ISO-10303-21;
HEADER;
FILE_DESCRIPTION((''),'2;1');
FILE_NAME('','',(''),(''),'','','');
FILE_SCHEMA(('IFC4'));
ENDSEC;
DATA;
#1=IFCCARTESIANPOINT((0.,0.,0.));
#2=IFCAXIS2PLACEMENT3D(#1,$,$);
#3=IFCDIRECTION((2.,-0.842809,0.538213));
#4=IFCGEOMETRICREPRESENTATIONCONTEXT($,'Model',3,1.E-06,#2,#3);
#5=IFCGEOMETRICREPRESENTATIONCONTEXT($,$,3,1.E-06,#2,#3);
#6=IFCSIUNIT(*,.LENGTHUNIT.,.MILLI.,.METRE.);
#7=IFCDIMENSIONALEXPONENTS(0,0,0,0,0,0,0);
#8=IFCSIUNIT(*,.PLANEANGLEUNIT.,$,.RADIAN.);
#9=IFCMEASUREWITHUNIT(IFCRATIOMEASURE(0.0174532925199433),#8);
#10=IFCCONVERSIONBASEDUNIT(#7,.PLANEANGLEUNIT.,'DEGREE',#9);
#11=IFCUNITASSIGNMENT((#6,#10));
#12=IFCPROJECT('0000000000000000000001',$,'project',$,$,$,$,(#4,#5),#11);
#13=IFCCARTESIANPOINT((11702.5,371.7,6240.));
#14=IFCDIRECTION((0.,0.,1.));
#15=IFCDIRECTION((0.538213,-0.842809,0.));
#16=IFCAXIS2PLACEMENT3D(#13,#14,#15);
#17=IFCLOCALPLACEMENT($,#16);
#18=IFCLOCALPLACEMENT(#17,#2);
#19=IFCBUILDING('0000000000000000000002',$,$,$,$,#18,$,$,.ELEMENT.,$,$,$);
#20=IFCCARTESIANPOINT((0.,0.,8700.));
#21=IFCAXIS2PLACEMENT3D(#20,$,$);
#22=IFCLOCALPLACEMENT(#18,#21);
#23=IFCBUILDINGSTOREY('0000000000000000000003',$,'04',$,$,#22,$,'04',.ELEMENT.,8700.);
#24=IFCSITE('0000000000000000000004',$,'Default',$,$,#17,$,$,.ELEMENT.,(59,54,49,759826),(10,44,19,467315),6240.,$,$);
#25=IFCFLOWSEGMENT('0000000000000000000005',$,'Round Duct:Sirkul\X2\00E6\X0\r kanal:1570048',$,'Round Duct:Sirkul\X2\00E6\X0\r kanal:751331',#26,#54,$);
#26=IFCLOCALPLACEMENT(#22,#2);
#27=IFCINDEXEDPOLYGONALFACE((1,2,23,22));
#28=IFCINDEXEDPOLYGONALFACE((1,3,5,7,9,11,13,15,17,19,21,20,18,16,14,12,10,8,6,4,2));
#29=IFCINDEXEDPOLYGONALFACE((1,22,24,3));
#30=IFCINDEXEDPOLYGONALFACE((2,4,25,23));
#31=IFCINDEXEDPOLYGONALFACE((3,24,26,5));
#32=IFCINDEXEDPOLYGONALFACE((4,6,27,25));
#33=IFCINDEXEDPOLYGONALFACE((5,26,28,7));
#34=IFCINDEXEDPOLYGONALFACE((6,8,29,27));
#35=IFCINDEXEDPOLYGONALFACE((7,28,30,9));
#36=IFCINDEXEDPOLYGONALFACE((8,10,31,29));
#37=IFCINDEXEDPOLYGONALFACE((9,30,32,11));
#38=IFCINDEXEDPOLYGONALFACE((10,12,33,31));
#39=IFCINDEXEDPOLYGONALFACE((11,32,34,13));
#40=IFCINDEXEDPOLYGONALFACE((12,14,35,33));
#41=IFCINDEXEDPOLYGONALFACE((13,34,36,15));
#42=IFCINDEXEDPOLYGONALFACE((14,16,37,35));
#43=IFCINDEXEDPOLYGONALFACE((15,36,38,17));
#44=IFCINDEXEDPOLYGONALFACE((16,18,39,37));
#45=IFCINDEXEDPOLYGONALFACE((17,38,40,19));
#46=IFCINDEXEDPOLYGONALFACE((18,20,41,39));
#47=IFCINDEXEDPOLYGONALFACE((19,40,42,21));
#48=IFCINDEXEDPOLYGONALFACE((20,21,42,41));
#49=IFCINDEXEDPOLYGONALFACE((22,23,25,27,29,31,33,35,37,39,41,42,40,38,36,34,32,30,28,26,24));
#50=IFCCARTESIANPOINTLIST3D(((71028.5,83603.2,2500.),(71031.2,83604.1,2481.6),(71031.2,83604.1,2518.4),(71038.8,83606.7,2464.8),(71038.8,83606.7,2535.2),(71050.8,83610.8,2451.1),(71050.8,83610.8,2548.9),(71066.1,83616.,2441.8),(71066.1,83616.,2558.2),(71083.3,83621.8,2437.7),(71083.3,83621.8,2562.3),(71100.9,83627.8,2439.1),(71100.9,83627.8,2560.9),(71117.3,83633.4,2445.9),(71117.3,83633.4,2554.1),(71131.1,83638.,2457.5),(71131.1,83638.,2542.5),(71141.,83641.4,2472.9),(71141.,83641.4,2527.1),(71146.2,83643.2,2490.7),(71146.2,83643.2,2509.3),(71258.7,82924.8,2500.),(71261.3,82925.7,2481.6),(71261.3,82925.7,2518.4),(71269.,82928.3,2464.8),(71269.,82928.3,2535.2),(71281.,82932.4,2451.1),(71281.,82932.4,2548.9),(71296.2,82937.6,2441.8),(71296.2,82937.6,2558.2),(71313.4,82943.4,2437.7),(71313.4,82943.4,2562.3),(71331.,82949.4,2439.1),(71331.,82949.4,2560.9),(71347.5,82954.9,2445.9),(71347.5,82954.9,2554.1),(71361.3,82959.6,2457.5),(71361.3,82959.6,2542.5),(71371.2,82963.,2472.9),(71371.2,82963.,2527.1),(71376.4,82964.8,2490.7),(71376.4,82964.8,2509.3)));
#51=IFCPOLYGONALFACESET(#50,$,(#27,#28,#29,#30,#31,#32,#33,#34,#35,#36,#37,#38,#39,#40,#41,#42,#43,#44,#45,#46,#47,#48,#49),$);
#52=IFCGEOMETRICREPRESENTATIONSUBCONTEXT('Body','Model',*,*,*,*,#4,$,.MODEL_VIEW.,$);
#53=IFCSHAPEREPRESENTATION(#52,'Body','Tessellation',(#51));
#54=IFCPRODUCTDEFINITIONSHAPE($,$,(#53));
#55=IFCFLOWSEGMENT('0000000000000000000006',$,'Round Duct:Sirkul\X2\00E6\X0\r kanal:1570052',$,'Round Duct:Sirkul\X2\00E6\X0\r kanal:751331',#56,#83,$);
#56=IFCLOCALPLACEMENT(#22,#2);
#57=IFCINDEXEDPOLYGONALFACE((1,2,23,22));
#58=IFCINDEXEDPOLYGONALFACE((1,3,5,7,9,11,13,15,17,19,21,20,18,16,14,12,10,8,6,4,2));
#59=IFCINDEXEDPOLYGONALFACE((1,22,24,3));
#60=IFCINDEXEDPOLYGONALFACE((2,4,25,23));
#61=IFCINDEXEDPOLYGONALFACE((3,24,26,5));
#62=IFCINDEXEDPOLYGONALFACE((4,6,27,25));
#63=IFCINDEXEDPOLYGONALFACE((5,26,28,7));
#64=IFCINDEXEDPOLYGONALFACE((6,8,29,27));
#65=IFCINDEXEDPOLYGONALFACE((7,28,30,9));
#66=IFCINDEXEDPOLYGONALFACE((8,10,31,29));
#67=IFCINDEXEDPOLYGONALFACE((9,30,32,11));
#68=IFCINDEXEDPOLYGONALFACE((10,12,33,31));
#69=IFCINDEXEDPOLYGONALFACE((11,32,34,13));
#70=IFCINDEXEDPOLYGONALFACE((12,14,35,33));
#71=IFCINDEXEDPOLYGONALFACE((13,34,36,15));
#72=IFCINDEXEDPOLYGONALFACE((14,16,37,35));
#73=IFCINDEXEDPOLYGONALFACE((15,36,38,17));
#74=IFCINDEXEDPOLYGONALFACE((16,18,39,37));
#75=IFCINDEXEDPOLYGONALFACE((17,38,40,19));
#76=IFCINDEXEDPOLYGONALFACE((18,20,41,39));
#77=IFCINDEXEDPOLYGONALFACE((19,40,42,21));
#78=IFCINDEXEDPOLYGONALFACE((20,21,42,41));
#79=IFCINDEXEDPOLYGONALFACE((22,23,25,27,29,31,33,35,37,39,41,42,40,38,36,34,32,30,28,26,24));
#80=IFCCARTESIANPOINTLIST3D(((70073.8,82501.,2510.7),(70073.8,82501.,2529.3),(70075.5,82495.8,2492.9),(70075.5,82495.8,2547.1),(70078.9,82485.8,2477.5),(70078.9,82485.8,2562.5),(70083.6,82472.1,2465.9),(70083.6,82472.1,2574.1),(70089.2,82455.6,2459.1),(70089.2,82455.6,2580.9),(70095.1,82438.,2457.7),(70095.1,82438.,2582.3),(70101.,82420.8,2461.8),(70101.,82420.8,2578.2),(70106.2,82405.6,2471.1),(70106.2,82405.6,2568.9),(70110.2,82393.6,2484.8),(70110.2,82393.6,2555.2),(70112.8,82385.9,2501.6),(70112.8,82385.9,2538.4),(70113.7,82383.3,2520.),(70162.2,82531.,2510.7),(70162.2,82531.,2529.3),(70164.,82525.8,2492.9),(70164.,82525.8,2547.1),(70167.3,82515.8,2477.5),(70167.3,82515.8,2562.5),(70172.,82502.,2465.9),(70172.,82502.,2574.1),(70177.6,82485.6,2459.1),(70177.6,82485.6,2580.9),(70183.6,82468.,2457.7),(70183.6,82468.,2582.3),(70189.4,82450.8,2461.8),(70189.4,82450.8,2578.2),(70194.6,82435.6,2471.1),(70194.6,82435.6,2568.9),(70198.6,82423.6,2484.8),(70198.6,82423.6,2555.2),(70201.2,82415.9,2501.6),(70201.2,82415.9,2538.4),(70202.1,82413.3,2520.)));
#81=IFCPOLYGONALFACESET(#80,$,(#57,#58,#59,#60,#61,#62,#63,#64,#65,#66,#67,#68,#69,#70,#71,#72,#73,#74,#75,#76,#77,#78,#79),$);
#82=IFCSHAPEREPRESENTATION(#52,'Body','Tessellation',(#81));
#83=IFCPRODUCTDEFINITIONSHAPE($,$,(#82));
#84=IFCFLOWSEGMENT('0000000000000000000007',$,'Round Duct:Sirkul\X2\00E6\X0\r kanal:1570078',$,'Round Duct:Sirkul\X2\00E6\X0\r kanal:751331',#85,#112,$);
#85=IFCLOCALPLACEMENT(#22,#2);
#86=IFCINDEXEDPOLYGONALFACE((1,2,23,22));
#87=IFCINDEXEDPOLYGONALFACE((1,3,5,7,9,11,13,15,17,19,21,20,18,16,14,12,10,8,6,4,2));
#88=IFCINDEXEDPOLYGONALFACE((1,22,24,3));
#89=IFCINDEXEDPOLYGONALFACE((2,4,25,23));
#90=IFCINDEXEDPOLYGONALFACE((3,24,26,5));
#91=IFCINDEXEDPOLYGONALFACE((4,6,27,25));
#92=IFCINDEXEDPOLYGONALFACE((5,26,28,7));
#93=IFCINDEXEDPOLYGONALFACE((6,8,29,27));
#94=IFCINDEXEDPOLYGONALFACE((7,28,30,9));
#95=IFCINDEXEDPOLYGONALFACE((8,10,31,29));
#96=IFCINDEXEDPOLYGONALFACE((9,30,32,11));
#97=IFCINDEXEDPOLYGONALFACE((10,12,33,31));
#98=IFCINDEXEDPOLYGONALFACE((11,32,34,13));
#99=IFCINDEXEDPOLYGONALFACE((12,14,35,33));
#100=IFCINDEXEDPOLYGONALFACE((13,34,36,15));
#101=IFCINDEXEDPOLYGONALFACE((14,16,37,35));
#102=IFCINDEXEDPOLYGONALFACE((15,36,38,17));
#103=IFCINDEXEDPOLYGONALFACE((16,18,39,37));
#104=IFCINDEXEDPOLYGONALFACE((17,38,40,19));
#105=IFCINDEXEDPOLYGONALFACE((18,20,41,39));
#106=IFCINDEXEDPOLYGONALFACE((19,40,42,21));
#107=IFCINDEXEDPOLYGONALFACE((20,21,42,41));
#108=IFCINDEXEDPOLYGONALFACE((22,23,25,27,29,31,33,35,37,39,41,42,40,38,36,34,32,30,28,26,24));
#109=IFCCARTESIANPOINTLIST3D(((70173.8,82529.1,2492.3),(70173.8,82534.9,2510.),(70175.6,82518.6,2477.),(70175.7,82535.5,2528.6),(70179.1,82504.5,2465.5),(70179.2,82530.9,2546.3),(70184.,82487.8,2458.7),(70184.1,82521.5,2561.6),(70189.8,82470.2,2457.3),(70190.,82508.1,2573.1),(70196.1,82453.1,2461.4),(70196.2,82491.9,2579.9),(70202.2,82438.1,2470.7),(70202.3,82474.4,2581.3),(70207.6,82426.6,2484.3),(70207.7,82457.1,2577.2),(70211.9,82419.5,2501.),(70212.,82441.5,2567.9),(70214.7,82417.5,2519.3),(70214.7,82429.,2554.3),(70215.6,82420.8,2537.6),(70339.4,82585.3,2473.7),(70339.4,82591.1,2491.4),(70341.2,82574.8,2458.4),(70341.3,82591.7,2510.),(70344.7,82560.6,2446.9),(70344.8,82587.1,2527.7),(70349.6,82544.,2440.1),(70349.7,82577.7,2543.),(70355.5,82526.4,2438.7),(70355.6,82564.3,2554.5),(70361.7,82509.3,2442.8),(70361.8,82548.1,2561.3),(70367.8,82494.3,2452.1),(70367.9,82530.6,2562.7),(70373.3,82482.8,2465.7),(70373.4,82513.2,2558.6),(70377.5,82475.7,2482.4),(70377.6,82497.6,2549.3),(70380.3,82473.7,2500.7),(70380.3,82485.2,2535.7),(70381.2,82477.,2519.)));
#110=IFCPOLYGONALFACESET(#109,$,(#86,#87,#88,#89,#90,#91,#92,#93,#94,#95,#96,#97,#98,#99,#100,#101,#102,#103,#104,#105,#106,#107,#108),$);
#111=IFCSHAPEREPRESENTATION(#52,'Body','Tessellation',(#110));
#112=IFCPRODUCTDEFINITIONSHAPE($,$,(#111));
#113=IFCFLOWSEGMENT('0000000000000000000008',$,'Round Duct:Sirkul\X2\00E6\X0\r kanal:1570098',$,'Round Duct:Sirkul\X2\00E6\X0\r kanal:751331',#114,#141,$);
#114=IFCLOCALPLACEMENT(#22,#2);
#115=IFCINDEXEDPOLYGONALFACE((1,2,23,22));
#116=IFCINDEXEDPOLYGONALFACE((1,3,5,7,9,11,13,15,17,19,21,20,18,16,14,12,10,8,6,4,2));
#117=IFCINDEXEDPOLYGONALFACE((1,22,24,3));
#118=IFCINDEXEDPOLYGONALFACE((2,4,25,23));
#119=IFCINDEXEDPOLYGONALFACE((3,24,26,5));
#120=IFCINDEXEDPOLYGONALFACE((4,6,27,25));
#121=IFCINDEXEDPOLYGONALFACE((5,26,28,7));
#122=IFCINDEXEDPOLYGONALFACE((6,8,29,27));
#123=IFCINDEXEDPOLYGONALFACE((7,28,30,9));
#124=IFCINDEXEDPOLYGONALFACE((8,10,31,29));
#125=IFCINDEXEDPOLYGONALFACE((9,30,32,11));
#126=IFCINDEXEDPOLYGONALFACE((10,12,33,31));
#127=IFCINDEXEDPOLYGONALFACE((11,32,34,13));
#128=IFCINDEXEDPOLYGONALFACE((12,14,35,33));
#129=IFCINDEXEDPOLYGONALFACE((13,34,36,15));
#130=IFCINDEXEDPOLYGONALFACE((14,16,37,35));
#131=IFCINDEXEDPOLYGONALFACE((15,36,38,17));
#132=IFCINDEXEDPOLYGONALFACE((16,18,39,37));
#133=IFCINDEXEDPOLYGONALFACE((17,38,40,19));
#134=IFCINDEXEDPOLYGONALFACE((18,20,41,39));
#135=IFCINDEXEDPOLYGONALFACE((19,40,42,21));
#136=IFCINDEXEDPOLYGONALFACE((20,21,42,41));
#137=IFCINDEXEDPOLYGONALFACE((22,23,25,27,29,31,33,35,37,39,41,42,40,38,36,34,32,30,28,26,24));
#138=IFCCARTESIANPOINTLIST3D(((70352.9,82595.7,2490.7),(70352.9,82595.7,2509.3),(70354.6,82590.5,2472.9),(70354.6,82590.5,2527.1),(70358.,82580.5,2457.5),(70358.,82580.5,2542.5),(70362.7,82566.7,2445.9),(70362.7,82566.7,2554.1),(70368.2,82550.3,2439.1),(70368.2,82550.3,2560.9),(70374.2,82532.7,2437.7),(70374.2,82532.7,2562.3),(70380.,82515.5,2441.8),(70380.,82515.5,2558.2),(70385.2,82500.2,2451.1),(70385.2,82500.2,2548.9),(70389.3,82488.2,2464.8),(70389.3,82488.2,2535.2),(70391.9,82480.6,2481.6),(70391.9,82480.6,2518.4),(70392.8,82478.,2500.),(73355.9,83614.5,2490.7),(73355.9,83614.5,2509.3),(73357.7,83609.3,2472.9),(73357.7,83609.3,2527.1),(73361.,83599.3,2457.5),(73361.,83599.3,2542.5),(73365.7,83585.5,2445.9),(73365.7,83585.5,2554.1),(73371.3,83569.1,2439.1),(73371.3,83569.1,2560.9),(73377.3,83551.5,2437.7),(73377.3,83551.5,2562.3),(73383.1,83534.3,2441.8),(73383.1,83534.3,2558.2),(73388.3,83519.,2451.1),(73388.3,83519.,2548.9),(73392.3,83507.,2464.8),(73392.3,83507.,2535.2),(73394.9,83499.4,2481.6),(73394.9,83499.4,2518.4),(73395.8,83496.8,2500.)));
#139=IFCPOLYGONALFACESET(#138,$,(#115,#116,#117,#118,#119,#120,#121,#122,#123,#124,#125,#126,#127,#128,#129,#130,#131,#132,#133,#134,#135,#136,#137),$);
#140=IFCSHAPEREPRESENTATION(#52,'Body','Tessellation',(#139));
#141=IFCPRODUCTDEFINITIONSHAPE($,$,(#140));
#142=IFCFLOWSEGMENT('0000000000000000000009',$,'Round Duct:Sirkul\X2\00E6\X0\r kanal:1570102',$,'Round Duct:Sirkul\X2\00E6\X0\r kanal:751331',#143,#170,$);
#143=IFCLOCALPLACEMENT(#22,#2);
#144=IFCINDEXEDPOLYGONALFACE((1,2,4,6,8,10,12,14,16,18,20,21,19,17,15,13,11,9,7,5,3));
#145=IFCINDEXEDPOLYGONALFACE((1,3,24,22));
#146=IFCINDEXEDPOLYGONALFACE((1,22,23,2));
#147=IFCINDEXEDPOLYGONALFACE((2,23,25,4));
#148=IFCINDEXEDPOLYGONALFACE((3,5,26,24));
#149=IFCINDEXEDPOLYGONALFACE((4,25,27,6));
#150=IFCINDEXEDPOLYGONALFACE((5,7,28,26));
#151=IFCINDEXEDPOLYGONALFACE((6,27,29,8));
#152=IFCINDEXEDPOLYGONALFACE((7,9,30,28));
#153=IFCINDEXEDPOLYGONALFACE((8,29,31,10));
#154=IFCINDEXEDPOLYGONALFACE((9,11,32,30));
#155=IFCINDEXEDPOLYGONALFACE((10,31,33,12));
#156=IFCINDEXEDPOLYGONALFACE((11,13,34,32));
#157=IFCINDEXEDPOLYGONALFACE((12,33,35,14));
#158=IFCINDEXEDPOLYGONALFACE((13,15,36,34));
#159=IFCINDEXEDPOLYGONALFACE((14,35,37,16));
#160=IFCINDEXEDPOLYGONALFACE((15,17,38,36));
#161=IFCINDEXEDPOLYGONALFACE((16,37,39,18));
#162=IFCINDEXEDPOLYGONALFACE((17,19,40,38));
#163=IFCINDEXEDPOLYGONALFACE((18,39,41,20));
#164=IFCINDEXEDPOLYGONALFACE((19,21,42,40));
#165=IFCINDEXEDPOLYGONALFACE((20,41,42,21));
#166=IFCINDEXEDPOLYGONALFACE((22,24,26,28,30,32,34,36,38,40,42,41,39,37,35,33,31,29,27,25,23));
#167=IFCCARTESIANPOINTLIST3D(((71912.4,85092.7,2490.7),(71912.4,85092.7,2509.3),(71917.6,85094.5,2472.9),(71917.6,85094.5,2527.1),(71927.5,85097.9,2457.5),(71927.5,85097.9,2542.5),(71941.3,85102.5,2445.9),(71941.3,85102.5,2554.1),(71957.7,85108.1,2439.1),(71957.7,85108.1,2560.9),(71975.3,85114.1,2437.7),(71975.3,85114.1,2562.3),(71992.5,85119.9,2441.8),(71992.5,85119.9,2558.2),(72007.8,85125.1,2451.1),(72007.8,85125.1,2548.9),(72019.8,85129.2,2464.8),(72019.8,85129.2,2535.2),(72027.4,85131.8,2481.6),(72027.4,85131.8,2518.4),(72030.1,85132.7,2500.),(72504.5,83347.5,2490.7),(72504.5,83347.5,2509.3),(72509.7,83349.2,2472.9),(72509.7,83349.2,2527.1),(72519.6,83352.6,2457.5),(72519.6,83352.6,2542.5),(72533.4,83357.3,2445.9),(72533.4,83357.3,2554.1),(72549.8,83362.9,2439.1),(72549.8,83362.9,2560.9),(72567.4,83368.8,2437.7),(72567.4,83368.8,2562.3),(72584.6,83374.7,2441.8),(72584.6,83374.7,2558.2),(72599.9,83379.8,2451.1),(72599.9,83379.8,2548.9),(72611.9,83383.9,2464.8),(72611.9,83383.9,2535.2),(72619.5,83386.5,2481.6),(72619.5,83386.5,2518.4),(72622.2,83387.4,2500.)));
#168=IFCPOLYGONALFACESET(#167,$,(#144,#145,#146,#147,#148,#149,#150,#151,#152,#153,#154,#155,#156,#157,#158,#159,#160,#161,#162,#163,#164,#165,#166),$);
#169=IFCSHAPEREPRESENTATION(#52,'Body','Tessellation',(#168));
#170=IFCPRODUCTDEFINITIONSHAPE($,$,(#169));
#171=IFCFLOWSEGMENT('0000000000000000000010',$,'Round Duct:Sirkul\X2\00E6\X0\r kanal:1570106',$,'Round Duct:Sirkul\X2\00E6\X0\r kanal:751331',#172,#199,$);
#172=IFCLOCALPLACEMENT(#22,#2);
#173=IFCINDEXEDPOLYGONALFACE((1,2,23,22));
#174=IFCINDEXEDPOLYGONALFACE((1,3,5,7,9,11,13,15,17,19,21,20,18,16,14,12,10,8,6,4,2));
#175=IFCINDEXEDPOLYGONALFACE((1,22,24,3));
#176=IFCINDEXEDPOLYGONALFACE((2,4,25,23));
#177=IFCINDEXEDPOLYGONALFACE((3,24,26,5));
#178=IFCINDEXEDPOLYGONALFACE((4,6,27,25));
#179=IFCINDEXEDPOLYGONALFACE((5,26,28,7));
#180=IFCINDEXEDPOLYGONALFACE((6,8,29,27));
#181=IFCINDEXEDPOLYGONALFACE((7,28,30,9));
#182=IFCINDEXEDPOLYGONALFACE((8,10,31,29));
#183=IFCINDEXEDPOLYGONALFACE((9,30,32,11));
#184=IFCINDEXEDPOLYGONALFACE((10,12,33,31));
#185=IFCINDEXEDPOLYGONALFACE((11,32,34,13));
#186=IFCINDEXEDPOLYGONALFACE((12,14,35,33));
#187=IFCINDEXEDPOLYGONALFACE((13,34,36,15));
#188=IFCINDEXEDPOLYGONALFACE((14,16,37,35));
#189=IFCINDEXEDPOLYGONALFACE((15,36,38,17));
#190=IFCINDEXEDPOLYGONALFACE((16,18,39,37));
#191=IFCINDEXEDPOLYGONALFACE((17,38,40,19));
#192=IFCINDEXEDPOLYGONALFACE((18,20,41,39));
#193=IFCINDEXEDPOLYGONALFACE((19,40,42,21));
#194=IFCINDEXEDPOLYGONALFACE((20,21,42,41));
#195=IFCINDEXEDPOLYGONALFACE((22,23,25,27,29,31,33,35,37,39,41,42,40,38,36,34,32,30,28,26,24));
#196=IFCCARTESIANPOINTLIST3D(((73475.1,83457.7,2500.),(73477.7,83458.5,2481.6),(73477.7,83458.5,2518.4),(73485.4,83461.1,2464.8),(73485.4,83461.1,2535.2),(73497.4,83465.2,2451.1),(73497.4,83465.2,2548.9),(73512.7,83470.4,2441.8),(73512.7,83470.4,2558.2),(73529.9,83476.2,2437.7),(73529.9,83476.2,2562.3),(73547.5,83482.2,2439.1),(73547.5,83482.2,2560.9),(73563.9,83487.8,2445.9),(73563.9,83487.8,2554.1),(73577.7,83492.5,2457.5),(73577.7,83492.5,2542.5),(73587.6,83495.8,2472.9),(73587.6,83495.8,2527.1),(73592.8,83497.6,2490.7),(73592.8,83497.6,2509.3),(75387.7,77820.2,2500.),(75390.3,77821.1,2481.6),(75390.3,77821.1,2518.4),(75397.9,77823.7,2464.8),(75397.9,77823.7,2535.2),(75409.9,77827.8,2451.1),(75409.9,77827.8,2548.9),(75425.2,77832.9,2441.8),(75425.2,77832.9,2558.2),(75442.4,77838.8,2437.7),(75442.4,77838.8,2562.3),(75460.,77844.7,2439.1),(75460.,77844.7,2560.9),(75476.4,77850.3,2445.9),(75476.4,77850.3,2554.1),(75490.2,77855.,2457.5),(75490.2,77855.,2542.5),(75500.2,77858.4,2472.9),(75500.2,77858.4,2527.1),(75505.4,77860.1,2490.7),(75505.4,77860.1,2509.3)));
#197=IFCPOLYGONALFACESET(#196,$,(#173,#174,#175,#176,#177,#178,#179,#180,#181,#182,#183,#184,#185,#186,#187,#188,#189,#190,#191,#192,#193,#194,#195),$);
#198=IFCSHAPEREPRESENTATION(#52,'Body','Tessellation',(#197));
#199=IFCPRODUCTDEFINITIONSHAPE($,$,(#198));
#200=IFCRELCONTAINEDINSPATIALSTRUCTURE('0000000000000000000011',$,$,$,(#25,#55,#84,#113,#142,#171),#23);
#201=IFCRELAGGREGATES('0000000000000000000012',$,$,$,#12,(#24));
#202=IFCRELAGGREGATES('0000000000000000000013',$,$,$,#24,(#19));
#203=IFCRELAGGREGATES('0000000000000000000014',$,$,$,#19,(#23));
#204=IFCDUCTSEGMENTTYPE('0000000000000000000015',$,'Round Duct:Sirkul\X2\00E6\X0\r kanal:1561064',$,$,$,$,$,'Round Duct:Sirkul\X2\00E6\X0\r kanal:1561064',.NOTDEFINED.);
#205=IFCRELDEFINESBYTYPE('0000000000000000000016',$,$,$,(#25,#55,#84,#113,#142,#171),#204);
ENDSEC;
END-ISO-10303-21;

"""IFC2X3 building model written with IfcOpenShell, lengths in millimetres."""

from ifc_helpers import new_model, entity, si_unit, converted_unit, direction, frame, frame_2d, origin, origin_2d_with_axis, place, context, subcontext, project, spatial, circle, extrude, type_object, element, save


model = new_model("IFC2X3")

# Units and contexts
model_context = context("Model", 3, precision=1e-06, world=origin(), true_north=direction((2.0, -0.842809, 0.538213)))
context_of_model = context(None, 3, precision=1e-06, world=origin(), true_north=direction((2.0, -0.842809, 0.538213)))
body_context = subcontext(model_context, "Body", "Model", "MODEL_VIEW")
ifc_project = project(units=[si_unit("LENGTHUNIT", "METRE", prefix="MILLI"), converted_unit("PLANEANGLEUNIT", "DEGREE", entity("IfcRatioMeasure", 0.0174532925199433), si_unit("PLANEANGLEUNIT", "RADIAN"), dimensions=[0, 0, 0, 0, 0, 0, 0])], contexts=[model_context, context_of_model])

# Site, building, storey
site_placement = place(None, frame((11702.5, 371.7, 6240.0), z_axis=(0.0, 0.0, 1.0), x_axis=(0.538213, -0.842809, 0.0)))
site = spatial("IfcSite", under=ifc_project, at=site_placement, Name="Default", CompositionType="ELEMENT", RefLatitude=(59, 54, 49, 759826), RefLongitude=(10, 44, 19, 467315), RefElevation=6240.0)
building_placement = place(site_placement, origin())
building = spatial("IfcBuilding", under=site, at=building_placement, CompositionType="ELEMENT")
storey_placement = place(building_placement, frame((0.0, 0.0, 8700.0)))
storey = spatial("IfcBuildingStorey", under=building, at=storey_placement, Name="04", LongName="04", CompositionType="ELEMENT", Elevation=8700.0)

# Flow segments
duct_segment_type = type_object("IfcDuctSegmentType", Name="Round Duct:Sirkulær kanal:1561064", ElementType="Round Duct:Sirkulær kanal:1561064", PredefinedType="NOTDEFINED")
flow_segment_1_placement = place(storey_placement, origin())
element("IfcFlowSegment", 1, at=flow_segment_1_placement, inside=storey, type_object=duct_segment_type, Name="Round Duct:Sirkulær kanal:1570048", ObjectType="Round Duct:Sirkulær kanal:751331", context=body_context, shape_type="SweptSolid", body=[
    extrude(circle(Radius=62.5, at=origin_2d_with_axis()), frame((71087.7, 83623.3, 2500.0), z_axis=(0.321274, -0.946986, 0.0), x_axis=(-0.946986, -0.321274, 0.0)), (0.0, 0.0, 1.0), 716.4),
])
flow_segment_2_placement = place(storey_placement, origin())
element("IfcFlowSegment", 2, at=flow_segment_2_placement, inside=storey, type_object=duct_segment_type, Name="Round Duct:Sirkulær kanal:1570052", ObjectType="Round Duct:Sirkulær kanal:751331", context=body_context, shape_type="SweptSolid", body=[
    extrude(circle(Radius=62.5, at=origin_2d_with_axis()), frame((70093.6, 82442.5, 2520.0), z_axis=(0.946986, 0.321274, 0.0), x_axis=(0.321274, -0.946986, 0.0)), (0.0, 0.0, 1.0), 93.4),
])
flow_segment_3_placement = place(storey_placement, origin())
element("IfcFlowSegment", 3, at=flow_segment_3_placement, inside=storey, type_object=duct_segment_type, Name="Round Duct:Sirkulær kanal:1570078", ObjectType="Round Duct:Sirkulær kanal:751331", context=body_context, shape_type="SweptSolid", body=[
    extrude(circle(Radius=62.5, at=origin_2d_with_axis()), frame((70360.2, 82532.9, 2500.7), z_axis=(-0.941677, -0.319473, 0.105746), x_axis=(0.321274, -0.946986, 0.0)), (0.0, 0.0, 1.0), 175.9),
])
flow_segment_4_placement = place(storey_placement, origin())
element("IfcFlowSegment", 4, at=flow_segment_4_placement, inside=storey, type_object=duct_segment_type, Name="Round Duct:Sirkulær kanal:1570098", ObjectType="Round Duct:Sirkulær kanal:751331", context=body_context, shape_type="SweptSolid", body=[
    extrude(circle(Radius=62.5, at=origin_2d_with_axis()), frame((70372.7, 82537.1, 2500.0), z_axis=(0.946986, 0.321274, 0.0), x_axis=(0.321274, -0.946986, 0.0)), (0.0, 0.0, 1.0), 3171.2),
])
flow_segment_5_placement = place(storey_placement, origin())
element("IfcFlowSegment", 5, at=flow_segment_5_placement, inside=storey, type_object=duct_segment_type, Name="Round Duct:Sirkulær kanal:1570102", ObjectType="Round Duct:Sirkulær kanal:751331", context=body_context, shape_type="SweptSolid", body=[
    extrude(circle(Radius=62.5, at=origin_2d_with_axis()), frame((71970.9, 85112.6, 2500.0), z_axis=(0.321274, -0.946986, 0.0), x_axis=(0.946986, 0.321274, 0.0)), (0.0, 0.0, 1.0), 1842.9),
])
flow_segment_6_placement = place(storey_placement, origin())
element("IfcFlowSegment", 6, at=flow_segment_6_placement, inside=storey, type_object=duct_segment_type, Name="Round Duct:Sirkulær kanal:1570106", ObjectType="Round Duct:Sirkulær kanal:751331", context=body_context, shape_type="SweptSolid", body=[
    extrude(circle(Radius=62.5, at=frame_2d((0.0, 0.0), x_axis=(1.0, 0.0))), frame((73534.3, 83477.7, 2500.0), z_axis=(0.321274, -0.946986, 0.0), x_axis=(-0.946986, -0.321274, 0.0)), (0.0, 0.0, 1.0), 5953.1),
])

save(model, "model.ifc")
